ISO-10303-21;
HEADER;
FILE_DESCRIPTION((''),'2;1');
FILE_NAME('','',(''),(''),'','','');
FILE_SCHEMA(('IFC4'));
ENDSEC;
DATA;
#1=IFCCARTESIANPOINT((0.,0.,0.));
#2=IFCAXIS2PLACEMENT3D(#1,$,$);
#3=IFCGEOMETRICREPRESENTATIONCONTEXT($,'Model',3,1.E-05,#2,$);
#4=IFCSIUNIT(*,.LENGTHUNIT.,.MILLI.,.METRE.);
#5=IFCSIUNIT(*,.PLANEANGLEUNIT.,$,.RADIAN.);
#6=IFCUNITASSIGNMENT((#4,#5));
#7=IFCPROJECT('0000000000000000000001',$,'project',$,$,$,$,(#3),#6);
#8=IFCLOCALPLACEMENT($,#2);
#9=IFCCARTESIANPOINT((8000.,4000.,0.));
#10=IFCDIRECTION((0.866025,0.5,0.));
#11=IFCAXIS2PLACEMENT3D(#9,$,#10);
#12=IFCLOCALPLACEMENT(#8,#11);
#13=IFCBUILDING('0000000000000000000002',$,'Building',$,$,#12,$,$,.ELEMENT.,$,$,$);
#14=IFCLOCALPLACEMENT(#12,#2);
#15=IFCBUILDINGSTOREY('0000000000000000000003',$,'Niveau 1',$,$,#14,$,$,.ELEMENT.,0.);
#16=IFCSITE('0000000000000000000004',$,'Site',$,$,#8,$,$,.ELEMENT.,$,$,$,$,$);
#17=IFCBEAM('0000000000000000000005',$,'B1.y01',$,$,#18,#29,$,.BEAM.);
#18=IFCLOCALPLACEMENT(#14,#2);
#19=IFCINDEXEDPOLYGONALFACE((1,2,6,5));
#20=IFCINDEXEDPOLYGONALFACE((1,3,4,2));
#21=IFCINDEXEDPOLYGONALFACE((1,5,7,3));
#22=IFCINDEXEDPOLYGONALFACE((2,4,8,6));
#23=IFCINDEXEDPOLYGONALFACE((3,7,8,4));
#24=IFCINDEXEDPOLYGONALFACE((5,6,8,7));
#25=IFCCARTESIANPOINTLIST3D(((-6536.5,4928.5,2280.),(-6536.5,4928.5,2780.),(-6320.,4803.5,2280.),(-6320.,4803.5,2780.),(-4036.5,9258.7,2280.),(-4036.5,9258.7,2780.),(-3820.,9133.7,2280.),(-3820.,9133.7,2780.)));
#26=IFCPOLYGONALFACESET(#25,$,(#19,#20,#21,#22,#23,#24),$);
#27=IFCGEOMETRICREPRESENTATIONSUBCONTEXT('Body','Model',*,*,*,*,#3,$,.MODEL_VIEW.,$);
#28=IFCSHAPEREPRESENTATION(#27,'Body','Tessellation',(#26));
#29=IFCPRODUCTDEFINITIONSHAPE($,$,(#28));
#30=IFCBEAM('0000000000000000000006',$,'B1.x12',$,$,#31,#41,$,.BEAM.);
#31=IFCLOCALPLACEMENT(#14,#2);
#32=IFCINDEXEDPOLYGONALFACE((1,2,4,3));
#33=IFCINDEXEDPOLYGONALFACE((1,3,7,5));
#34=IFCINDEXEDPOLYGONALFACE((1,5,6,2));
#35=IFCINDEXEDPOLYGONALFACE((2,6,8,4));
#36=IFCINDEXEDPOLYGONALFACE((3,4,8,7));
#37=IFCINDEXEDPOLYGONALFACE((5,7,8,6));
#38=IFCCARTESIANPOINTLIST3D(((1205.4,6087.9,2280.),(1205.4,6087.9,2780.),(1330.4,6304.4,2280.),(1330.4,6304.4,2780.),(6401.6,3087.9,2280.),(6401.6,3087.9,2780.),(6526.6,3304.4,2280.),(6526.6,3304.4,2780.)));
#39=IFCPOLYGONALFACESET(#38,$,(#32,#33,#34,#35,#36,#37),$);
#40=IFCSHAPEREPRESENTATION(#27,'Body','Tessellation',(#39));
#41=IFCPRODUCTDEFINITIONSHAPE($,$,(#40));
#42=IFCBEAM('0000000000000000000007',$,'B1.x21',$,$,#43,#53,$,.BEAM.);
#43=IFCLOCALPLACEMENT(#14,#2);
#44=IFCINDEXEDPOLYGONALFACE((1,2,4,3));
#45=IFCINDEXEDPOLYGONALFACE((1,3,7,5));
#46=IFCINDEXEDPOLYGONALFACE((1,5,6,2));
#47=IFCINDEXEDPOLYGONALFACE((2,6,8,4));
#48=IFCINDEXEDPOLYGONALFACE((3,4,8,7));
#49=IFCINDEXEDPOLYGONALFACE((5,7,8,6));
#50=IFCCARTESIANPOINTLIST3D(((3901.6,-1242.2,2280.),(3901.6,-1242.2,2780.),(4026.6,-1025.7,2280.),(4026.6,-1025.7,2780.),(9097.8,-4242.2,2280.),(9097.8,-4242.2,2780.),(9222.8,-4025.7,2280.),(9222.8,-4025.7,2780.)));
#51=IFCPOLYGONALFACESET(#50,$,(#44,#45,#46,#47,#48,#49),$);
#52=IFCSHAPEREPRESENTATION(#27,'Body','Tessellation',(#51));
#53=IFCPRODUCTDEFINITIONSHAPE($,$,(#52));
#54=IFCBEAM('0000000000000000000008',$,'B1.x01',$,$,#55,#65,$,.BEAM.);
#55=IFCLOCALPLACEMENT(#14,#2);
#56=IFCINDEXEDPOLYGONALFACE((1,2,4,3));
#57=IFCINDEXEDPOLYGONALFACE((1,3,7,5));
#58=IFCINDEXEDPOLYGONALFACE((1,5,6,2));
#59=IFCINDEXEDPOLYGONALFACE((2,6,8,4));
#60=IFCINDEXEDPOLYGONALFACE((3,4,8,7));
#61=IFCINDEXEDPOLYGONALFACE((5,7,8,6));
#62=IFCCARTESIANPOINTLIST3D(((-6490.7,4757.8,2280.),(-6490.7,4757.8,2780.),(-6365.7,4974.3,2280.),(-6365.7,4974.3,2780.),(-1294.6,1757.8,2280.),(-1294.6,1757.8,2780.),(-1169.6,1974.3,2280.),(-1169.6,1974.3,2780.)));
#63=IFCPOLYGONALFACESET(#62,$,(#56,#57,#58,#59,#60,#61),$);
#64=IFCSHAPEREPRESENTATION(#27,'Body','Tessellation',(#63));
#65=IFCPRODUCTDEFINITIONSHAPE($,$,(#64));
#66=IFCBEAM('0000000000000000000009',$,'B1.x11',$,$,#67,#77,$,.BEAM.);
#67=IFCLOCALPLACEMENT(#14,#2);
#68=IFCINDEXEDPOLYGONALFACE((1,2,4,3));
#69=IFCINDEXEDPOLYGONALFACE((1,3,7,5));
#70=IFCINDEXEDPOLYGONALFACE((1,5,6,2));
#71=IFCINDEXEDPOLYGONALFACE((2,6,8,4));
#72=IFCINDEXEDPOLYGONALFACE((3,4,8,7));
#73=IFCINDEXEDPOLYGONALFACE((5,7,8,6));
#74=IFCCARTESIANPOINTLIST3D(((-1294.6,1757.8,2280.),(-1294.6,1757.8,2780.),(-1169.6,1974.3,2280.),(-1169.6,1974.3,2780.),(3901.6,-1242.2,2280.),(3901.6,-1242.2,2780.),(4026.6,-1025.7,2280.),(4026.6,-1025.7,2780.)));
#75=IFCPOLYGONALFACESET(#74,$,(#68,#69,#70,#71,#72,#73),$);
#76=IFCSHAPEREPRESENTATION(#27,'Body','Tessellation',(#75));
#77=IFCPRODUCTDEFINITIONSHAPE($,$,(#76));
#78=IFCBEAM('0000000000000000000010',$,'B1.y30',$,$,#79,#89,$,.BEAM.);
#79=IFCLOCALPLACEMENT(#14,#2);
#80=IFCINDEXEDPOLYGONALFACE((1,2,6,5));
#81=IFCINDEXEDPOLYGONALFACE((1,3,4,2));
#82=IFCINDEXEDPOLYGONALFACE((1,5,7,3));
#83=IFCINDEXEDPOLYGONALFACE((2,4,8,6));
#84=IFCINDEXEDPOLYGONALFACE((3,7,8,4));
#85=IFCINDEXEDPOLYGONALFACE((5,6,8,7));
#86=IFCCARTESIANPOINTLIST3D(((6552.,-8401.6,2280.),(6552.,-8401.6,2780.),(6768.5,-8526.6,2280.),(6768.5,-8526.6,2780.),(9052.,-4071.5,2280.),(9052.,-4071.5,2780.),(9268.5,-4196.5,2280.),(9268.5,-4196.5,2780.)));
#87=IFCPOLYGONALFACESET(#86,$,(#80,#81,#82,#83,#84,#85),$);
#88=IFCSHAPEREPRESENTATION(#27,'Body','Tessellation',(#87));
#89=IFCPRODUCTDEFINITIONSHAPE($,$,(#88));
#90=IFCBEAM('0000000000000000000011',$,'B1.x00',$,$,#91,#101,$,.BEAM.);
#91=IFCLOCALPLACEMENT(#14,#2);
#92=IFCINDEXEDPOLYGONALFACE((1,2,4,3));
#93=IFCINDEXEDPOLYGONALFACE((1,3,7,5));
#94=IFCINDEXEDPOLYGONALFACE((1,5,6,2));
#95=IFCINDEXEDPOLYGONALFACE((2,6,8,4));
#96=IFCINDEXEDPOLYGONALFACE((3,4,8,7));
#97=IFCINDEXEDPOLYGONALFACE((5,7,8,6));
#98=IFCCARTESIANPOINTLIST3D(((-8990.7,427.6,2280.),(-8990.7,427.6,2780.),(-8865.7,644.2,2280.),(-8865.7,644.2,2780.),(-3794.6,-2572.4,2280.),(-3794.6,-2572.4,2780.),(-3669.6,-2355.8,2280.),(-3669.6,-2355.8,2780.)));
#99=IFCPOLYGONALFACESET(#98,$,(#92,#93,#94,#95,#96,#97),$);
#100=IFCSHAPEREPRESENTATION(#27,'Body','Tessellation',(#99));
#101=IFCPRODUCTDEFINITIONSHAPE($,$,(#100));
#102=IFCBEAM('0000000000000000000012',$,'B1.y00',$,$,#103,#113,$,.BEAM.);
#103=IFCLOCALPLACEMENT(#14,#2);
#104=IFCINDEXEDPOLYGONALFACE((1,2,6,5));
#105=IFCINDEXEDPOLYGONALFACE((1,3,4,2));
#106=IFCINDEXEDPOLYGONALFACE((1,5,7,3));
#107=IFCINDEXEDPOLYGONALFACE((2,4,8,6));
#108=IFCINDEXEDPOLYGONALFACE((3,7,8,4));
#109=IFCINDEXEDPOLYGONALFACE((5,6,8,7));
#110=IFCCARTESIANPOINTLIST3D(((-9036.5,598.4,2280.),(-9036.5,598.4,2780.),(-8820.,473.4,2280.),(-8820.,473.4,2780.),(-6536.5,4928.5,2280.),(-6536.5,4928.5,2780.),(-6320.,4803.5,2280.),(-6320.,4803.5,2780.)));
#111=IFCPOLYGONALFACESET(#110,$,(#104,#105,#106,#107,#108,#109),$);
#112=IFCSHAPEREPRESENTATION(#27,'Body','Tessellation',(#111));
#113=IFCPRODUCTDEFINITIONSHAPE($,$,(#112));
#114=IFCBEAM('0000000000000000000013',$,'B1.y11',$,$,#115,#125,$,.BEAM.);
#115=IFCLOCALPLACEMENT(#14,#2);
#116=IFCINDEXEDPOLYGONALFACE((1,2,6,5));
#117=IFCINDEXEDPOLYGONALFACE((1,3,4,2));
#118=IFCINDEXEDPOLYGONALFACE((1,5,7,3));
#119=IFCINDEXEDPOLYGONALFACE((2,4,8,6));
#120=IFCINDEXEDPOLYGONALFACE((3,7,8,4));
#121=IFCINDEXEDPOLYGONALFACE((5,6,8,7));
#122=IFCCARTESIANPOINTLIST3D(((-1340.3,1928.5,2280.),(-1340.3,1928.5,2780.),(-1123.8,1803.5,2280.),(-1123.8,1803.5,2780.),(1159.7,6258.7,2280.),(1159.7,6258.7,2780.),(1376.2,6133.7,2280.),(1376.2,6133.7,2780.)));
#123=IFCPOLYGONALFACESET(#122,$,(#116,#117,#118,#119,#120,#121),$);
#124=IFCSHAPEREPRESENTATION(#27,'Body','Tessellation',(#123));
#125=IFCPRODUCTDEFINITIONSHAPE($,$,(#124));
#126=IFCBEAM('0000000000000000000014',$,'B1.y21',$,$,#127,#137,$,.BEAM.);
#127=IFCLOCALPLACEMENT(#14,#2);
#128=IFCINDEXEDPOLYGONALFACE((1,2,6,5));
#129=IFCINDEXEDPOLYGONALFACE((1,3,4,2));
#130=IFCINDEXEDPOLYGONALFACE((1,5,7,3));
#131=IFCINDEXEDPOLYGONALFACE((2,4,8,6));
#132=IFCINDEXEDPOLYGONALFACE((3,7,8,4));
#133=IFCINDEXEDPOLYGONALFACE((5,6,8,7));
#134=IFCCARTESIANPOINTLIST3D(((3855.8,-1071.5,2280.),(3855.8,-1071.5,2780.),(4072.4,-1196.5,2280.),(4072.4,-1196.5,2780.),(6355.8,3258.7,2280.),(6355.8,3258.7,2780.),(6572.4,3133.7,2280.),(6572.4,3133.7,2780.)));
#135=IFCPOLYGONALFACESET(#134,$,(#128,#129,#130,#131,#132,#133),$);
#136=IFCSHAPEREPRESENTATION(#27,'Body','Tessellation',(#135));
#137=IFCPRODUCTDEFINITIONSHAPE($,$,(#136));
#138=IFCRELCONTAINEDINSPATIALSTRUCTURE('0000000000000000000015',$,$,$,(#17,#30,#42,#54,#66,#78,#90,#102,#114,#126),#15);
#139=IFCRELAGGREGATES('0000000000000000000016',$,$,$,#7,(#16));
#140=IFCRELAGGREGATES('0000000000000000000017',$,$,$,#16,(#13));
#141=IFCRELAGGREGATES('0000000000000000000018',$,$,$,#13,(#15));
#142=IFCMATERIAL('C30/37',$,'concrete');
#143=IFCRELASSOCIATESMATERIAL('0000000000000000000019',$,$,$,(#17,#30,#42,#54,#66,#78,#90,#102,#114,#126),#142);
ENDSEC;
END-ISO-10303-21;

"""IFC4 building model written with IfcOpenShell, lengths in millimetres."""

from ifc_helpers import new_model, si_unit, frame, origin, place, context, subcontext, project, spatial, rectangle, extrude, material, element, save


model = new_model("IFC4")

# Units and contexts
model_context = context("Model", 3, precision=1e-05, world=origin())
body_context = subcontext(model_context, "Body", "Model", "MODEL_VIEW")
ifc_project = project(units=[si_unit("LENGTHUNIT", "METRE", prefix="MILLI"), si_unit("PLANEANGLEUNIT", "RADIAN")], contexts=[model_context])

# Site, building, storey
site_placement = place(None, origin())
site = spatial("IfcSite", under=ifc_project, at=site_placement, Name="Site", CompositionType="ELEMENT")
building_placement = place(site_placement, frame((8000.0, 4000.0, 0.0), x_axis=(0.866025, 0.5, 0.0)))
building = spatial("IfcBuilding", under=site, at=building_placement, Name="Building", CompositionType="ELEMENT")
storey_placement = place(building_placement, origin())
storey = spatial("IfcBuildingStorey", under=building, at=storey_placement, Name="Niveau 1", CompositionType="ELEMENT", Elevation=0.0)

# Shared definitions
ifc_material = material(Name="C30/37", Category="concrete")

# Beams
beam_1_placement = place(storey_placement, frame((-6428.2, 4866.0, 2530.0), z_axis=(0.5, 0.866025, 0.0), x_axis=(-0.866025, 0.5, 0.0)))
element("IfcBeam", 1, at=beam_1_placement, inside=storey, material=ifc_material, Name="B1.y01", PredefinedType="BEAM", context=body_context, shape_type="SweptSolid", body=[
    extrude(rectangle(XDim=250.0, YDim=500.0), origin(), (0.0, 0.0, 1.0), 5000.0),
])
for number, where, z_axis, x_axis, name in (
    (2, (1267.9, 6196.2, 2530.0), (0.866025, -0.5, 0.0), (0.5, 0.866025, 0.0), "B1.x12"),
    (3, (3964.1, -1134.0, 2530.0), (0.866025, -0.5, 0.0), (0.5, 0.866025, 0.0), "B1.x21"),
    (4, (-6428.2, 4866.0, 2530.0), (0.866025, -0.5, 0.0), (0.5, 0.866025, 0.0), "B1.x01"),
    (5, (-1232.1, 1866.0, 2530.0), (0.866025, -0.5, 0.0), (0.5, 0.866025, 0.0), "B1.x11"),
):
    element("IfcBeam", number, at=place(storey_placement, frame(where, z_axis=z_axis, x_axis=x_axis)), inside=storey, material=ifc_material, Name=name, PredefinedType="BEAM", context=body_context, shape_type="SweptSolid", body=[
        extrude(rectangle(XDim=250.0, YDim=500.0), origin(), (0.0, 0.0, 1.0), 6000.0),
    ])
beam_2_placement = place(storey_placement, frame((6660.3, -8464.1, 2530.0), z_axis=(0.5, 0.866025, 0.0), x_axis=(-0.866025, 0.5, 0.0)))
element("IfcBeam", 6, at=beam_2_placement, inside=storey, material=ifc_material, Name="B1.y30", PredefinedType="BEAM", context=body_context, shape_type="SweptSolid", body=[
    extrude(rectangle(XDim=250.0, YDim=500.0), origin(), (0.0, 0.0, 1.0), 5000.0),
])
beam_3_placement = place(storey_placement, frame((-8928.2, 535.9, 2530.0), z_axis=(0.866025, -0.5, 0.0), x_axis=(0.5, 0.866025, 0.0)))
element("IfcBeam", 7, at=beam_3_placement, inside=storey, material=ifc_material, Name="B1.x00", PredefinedType="BEAM", context=body_context, shape_type="SweptSolid", body=[
    extrude(rectangle(XDim=250.0, YDim=500.0), origin(), (0.0, 0.0, 1.0), 6000.0),
])
for number, where, z_axis, x_axis, name in (
    (8, (-8928.2, 535.9, 2530.0), (0.5, 0.866025, 0.0), (-0.866025, 0.5, 0.0), "B1.y00"),
    (9, (-1232.1, 1866.0, 2530.0), (0.5, 0.866025, 0.0), (-0.866025, 0.5, 0.0), "B1.y11"),
    (10, (3964.1, -1134.0, 2530.0), (0.5, 0.866025, 0.0), (-0.866025, 0.5, 0.0), "B1.y21"),
):
    element("IfcBeam", number, at=place(storey_placement, frame(where, z_axis=z_axis, x_axis=x_axis)), inside=storey, material=ifc_material, Name=name, PredefinedType="BEAM", context=body_context, shape_type="SweptSolid", body=[
        extrude(rectangle(XDim=250.0, YDim=500.0), origin(), (0.0, 0.0, 1.0), 5000.0),
    ])

save(model, "model.ifc")
